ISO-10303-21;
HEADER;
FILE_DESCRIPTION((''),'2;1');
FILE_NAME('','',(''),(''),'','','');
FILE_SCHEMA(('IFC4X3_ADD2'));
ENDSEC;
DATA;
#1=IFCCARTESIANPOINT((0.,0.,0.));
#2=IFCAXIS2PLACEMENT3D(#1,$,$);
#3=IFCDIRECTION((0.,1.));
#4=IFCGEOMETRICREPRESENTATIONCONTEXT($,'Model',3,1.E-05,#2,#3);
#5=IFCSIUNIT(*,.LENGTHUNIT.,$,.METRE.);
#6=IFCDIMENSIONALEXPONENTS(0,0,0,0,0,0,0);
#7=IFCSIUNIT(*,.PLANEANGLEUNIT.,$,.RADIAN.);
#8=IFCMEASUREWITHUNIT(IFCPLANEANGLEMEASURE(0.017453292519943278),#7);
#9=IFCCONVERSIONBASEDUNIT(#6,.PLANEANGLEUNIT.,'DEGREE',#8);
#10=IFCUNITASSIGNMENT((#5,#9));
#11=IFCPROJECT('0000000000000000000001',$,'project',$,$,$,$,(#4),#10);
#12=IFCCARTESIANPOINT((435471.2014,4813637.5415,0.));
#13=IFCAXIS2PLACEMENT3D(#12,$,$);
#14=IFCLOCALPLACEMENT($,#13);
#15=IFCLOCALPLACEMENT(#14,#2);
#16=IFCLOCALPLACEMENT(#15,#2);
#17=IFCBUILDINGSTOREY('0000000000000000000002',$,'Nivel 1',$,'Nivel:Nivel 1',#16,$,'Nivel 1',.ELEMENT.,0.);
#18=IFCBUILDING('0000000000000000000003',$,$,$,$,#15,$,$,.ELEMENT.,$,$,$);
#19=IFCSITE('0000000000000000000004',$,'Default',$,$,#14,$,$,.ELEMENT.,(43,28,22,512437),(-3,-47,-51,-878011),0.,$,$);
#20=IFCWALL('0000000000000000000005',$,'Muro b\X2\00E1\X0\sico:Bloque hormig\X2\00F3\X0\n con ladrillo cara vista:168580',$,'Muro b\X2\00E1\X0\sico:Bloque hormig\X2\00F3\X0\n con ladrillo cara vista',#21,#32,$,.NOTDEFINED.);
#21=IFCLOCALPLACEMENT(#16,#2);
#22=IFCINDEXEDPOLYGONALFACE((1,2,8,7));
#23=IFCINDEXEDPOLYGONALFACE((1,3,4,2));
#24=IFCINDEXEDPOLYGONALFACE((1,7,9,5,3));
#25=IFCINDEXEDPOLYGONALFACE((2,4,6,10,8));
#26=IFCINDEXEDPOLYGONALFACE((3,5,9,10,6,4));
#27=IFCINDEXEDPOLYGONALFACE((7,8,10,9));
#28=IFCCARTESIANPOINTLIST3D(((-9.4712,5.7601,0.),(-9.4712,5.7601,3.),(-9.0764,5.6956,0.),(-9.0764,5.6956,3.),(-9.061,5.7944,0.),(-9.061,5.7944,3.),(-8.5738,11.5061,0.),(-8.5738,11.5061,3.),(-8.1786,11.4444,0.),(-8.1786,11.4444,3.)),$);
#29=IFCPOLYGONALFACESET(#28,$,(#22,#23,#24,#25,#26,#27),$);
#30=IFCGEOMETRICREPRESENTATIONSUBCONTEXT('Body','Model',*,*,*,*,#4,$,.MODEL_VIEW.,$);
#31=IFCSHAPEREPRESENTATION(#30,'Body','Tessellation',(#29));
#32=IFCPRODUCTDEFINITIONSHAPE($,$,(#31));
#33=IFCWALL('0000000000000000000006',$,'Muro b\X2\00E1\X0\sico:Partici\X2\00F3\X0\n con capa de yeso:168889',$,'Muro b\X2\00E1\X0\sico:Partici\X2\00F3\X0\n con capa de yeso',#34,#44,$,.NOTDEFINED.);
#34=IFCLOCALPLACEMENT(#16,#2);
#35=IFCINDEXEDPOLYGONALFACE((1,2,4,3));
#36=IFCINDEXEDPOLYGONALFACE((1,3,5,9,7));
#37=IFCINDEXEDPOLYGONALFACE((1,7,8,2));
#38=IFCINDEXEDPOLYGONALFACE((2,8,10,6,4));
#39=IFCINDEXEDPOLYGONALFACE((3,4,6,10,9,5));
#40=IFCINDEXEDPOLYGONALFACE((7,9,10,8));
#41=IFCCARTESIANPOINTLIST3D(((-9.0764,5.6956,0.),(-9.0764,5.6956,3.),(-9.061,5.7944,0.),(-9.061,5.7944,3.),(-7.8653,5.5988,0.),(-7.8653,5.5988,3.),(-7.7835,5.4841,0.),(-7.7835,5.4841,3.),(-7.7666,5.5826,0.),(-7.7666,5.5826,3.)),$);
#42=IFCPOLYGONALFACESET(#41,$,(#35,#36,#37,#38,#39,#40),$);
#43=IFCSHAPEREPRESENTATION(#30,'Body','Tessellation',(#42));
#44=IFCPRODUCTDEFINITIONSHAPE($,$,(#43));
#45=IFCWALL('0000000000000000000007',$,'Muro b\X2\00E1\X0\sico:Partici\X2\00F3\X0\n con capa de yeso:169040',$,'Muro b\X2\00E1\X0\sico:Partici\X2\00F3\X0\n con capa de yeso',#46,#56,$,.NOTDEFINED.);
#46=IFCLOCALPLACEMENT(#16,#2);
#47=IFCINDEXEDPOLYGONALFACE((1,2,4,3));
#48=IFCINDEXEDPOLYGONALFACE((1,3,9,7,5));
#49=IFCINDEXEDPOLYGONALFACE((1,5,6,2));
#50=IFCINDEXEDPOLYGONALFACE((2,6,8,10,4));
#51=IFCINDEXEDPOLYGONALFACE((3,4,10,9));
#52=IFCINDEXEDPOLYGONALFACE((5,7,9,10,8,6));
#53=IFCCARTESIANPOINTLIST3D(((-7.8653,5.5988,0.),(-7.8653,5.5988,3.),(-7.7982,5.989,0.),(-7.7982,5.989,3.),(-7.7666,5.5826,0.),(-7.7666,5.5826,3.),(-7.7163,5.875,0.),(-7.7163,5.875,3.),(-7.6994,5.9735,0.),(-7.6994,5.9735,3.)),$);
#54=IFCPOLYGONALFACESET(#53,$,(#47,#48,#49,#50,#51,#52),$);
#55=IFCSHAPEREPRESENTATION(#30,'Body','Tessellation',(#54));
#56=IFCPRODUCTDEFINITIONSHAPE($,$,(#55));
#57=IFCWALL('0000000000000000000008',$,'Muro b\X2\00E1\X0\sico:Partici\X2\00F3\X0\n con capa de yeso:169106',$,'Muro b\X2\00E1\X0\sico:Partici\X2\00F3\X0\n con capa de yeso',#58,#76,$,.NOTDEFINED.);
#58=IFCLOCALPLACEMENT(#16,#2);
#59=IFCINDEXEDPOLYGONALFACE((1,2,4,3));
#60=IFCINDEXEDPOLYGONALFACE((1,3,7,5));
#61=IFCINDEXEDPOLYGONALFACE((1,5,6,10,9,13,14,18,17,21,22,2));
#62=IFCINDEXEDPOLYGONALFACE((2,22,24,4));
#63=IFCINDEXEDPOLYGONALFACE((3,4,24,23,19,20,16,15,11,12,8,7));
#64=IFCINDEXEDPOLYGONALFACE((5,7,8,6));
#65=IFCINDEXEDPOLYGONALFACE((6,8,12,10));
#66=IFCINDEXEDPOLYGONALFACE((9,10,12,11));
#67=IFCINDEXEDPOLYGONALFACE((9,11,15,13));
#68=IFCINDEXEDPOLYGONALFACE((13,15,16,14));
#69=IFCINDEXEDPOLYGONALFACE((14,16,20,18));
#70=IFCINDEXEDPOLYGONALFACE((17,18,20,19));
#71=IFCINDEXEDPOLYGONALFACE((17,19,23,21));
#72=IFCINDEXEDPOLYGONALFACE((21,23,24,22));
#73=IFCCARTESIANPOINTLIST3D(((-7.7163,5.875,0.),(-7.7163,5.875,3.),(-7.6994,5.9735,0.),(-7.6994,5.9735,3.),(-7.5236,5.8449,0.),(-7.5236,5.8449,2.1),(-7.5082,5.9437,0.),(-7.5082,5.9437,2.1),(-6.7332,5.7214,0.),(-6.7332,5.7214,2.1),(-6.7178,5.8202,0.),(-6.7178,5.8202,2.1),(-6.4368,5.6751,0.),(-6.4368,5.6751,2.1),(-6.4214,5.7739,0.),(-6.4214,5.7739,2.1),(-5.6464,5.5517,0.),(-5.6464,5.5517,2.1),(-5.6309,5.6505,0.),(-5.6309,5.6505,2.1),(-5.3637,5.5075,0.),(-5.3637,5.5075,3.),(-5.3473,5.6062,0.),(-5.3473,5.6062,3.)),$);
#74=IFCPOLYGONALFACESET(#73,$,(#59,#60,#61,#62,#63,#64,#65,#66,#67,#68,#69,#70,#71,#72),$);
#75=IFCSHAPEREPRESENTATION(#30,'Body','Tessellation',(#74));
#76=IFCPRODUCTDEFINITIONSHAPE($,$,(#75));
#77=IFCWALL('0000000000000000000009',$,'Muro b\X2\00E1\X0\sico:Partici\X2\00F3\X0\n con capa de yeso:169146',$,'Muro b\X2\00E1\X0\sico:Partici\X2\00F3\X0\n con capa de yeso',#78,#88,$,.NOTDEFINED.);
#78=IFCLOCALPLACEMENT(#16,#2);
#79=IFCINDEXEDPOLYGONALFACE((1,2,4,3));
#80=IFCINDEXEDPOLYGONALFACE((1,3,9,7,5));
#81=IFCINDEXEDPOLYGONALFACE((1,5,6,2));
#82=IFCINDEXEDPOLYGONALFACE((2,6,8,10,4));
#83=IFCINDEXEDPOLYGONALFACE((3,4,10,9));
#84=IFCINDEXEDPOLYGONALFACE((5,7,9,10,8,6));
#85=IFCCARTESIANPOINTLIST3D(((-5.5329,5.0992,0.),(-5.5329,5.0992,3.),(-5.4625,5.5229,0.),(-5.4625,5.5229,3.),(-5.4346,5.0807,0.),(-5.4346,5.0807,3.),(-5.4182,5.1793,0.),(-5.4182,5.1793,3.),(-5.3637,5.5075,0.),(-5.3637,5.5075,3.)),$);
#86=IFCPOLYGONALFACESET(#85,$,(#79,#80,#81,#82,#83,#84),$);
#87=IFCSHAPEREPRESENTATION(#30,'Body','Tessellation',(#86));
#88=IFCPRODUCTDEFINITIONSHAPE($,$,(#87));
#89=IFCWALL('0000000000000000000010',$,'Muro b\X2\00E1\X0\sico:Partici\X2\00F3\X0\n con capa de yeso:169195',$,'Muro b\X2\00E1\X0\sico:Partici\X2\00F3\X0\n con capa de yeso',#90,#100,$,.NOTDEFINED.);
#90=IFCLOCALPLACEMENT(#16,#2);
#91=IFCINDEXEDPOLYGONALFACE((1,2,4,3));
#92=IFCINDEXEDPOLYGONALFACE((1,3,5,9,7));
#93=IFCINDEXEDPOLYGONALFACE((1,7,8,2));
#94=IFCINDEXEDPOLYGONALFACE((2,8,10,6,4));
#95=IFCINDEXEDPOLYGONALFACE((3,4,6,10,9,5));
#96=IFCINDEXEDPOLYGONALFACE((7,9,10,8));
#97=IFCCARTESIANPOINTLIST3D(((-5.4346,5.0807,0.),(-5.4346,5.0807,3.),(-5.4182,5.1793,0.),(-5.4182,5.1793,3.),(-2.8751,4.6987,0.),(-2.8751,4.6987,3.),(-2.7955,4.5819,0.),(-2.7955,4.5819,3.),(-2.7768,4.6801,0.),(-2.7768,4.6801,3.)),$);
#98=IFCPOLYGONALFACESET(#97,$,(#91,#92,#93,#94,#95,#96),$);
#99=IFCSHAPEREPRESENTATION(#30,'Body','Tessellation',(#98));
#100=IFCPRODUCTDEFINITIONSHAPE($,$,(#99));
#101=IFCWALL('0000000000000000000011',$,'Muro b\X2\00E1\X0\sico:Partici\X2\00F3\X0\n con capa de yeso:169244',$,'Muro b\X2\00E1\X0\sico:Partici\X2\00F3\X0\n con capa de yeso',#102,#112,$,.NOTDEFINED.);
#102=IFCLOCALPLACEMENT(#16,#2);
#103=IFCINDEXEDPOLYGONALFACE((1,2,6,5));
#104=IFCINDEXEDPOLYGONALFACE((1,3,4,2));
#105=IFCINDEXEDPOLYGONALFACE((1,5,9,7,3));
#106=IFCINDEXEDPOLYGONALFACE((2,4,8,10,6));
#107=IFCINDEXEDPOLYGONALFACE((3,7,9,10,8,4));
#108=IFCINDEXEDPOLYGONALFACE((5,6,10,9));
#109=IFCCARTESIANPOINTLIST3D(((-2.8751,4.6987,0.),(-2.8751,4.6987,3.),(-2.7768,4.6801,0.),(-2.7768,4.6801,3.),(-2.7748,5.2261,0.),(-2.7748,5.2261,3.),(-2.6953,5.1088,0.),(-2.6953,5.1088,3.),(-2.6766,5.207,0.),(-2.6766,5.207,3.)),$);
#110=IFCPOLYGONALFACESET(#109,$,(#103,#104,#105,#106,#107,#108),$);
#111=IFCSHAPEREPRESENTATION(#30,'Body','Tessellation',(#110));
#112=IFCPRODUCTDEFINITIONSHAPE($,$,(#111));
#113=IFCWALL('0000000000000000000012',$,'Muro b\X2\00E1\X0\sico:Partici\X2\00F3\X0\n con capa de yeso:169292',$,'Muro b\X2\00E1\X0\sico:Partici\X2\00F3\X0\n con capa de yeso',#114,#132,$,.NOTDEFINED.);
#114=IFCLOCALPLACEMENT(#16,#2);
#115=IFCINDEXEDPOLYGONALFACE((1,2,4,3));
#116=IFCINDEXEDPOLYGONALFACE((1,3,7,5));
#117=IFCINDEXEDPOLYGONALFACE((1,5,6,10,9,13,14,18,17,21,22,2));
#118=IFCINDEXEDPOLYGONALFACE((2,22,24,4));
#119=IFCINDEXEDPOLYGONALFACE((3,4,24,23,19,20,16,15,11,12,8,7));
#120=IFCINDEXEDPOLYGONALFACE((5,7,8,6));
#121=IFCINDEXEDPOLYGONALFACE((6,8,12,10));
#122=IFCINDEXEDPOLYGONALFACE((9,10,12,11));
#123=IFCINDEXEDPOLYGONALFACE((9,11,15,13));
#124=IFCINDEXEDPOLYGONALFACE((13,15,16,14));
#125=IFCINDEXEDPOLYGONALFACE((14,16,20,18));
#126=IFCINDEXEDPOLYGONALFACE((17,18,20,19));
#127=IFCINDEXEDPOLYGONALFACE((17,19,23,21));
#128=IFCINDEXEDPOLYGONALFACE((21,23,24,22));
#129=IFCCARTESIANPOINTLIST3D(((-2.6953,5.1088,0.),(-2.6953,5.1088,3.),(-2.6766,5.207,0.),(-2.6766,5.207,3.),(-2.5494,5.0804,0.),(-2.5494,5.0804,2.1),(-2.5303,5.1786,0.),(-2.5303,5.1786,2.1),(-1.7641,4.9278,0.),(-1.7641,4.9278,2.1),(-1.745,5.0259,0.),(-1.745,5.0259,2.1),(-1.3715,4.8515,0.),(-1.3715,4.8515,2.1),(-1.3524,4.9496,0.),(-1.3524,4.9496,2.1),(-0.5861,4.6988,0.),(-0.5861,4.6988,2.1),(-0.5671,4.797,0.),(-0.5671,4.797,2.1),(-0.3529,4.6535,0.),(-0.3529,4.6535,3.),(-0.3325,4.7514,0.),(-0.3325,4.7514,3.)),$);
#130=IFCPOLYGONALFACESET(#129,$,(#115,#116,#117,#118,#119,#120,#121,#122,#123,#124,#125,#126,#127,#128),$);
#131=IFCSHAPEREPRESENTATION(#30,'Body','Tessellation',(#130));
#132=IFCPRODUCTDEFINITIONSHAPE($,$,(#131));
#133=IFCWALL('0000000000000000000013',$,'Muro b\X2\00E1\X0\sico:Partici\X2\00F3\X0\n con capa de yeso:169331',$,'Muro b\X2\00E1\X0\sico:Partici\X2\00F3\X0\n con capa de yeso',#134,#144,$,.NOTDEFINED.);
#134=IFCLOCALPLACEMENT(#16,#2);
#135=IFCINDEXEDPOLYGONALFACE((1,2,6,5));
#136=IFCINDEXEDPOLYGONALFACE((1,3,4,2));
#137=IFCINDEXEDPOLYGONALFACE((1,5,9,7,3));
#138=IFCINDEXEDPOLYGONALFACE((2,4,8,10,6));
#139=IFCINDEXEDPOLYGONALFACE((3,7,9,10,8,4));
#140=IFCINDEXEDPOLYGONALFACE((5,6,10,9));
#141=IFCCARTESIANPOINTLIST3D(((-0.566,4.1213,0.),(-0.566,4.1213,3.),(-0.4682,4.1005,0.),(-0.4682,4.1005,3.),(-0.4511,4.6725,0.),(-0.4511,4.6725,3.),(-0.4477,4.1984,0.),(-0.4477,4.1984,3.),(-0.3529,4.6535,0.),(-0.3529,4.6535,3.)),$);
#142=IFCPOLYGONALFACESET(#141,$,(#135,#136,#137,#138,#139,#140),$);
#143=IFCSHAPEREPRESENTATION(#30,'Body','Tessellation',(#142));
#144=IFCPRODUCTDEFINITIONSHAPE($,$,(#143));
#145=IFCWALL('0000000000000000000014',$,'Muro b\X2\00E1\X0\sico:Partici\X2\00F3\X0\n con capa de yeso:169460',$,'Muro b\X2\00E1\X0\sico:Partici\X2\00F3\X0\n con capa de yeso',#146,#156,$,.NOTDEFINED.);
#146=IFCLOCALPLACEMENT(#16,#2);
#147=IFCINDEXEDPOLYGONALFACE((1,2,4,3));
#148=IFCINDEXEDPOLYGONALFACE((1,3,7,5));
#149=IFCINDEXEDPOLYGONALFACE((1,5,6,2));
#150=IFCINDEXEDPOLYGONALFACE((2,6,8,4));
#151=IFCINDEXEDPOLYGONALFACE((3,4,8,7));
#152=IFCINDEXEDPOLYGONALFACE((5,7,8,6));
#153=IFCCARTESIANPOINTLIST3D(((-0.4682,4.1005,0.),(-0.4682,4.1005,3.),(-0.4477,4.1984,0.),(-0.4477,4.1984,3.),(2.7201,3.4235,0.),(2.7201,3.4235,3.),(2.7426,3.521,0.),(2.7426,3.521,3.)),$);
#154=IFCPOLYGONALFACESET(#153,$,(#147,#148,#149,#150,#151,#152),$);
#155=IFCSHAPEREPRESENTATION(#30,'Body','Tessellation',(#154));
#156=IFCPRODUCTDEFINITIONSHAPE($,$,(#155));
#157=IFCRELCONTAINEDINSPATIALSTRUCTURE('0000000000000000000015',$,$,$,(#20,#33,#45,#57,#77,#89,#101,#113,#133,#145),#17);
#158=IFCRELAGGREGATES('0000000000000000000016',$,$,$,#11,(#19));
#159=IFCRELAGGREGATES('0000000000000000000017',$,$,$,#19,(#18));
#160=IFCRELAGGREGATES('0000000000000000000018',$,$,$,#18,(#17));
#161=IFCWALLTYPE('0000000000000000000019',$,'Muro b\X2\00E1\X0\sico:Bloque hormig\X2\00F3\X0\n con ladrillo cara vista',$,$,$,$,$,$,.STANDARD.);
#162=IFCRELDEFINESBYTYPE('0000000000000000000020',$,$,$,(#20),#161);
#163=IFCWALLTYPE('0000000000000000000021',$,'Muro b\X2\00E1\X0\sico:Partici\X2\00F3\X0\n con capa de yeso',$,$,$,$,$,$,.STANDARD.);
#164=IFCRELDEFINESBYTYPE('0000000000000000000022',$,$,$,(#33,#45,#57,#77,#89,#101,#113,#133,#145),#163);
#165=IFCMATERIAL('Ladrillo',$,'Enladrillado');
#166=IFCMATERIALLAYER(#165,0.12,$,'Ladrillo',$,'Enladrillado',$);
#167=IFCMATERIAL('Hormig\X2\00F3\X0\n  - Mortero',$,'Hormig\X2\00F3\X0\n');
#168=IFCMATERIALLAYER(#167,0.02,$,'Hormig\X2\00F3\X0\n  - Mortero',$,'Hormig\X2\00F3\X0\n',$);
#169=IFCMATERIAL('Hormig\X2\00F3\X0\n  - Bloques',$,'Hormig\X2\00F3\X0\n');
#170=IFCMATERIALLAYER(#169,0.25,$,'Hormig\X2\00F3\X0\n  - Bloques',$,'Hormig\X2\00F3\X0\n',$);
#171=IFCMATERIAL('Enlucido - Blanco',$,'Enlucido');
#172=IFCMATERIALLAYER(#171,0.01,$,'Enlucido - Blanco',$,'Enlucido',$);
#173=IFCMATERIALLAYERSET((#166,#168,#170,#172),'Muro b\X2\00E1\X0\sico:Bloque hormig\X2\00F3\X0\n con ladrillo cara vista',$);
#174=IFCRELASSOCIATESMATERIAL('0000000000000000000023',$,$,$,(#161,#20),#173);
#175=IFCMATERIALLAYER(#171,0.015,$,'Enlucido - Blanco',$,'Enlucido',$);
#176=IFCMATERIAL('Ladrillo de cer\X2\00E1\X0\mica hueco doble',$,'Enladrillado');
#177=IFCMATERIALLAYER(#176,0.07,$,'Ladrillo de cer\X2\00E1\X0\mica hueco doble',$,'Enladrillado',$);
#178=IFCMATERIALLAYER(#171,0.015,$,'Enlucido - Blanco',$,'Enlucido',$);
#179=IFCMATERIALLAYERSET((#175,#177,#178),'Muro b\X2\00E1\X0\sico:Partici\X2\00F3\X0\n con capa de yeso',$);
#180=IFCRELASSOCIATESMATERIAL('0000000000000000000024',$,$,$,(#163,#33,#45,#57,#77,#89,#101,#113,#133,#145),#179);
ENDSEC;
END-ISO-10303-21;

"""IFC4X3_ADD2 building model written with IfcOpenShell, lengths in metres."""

from ifc_helpers import new_model, entity, si_unit, converted_unit, direction, frame, frame_2d, origin, place, context, subcontext, project, spatial, polyline, rectangle, outline, extrude, material, layer, layer_set, type_object, element, save


model = new_model("IFC4X3_ADD2")

# Units and contexts
model_context = context("Model", 3, precision=1e-05, world=origin(), true_north=direction((0.0, 1.0)))
body_context = subcontext(model_context, "Body", "Model", "MODEL_VIEW")
ifc_project = project(units=[si_unit("LENGTHUNIT", "METRE"), converted_unit("PLANEANGLEUNIT", "DEGREE", entity("IfcPlaneAngleMeasure", 0.017453292519943278), si_unit("PLANEANGLEUNIT", "RADIAN"), dimensions=[0, 0, 0, 0, 0, 0, 0])], contexts=[model_context])

# Site, building, storey
site_placement = place(None, frame((435471.2014, 4813637.5415, 0.0)))
site = spatial("IfcSite", under=ifc_project, at=site_placement, Name="Default", CompositionType="ELEMENT", RefLatitude=(43, 28, 22, 512437), RefLongitude=(-3, -47, -51, -878011), RefElevation=0.0)
building_placement = place(site_placement, origin())
building = spatial("IfcBuilding", under=site, at=building_placement, CompositionType="ELEMENT")
storey_placement = place(building_placement, origin())
storey = spatial("IfcBuildingStorey", under=building, at=storey_placement, Name="Nivel 1", ObjectType="Nivel:Nivel 1", LongName="Nivel 1", CompositionType="ELEMENT", Elevation=0.0)

# Walls
ifc_material_1 = material(Name="Ladrillo", Category="Enladrillado")
ifc_layer_1 = layer(ifc_material_1, 0.12, Name="Ladrillo", Category="Enladrillado")
ifc_material_2 = material(Name="Hormigón  - Mortero", Category="Hormigón")
ifc_layer_2 = layer(ifc_material_2, 0.02, Name="Hormigón  - Mortero", Category="Hormigón")
ifc_material_3 = material(Name="Hormigón  - Bloques", Category="Hormigón")
ifc_layer_3 = layer(ifc_material_3, 0.25, Name="Hormigón  - Bloques", Category="Hormigón")
ifc_material_4 = material(Name="Enlucido - Blanco", Category="Enlucido")
ifc_layer_4 = layer(ifc_material_4, 0.01, Name="Enlucido - Blanco", Category="Enlucido")
ifc_layer_set_1 = layer_set([ifc_layer_1, ifc_layer_2, ifc_layer_3, ifc_layer_4], Name="Muro básico:Bloque hormigón con ladrillo cara vista")
wall_type_1 = type_object("IfcWallType", Name="Muro básico:Bloque hormigón con ladrillo cara vista", PredefinedType="STANDARD", material=ifc_layer_set_1)
wall_1_placement = place(storey_placement, frame((-8.3762, 11.4752, 0.0), z_axis=(0.0, 0.0, 1.0), x_axis=(-0.154315, -0.988022, 0.0)))
element("IfcWall", 1, at=wall_1_placement, inside=storey, type_object=wall_type_1, material=ifc_layer_set_1, Name="Muro básico:Bloque hormigón con ladrillo cara vista:168580", ObjectType="Muro básico:Bloque hormigón con ladrillo cara vista", PredefinedType="NOTDEFINED", context=body_context, shape_type="SweptSolid", body=[
    extrude(outline(polyline([(5.8156, -0.2), (5.8185, 0.2), (5.7185, 0.2), (0.0, 0.2), (0.0, -0.2), (5.8156, -0.2)])), origin(), (0.0, 0.0, 1.0), 3.0),
])
ifc_layer_5 = layer(ifc_material_4, 0.015, Name="Enlucido - Blanco", Category="Enlucido")
ifc_material_5 = material(Name="Ladrillo de cerámica hueco doble", Category="Enladrillado")
ifc_layer_6 = layer(ifc_material_5, 0.07, Name="Ladrillo de cerámica hueco doble", Category="Enladrillado")
ifc_layer_7 = layer(ifc_material_4, 0.015, Name="Enlucido - Blanco", Category="Enlucido")
ifc_layer_set_2 = layer_set([ifc_layer_5, ifc_layer_6, ifc_layer_7], Name="Muro básico:Partición con capa de yeso")
wall_type_2 = type_object("IfcWallType", Name="Muro básico:Partición con capa de yeso", PredefinedType="STANDARD", material=ifc_layer_set_2)
wall_2_placement = place(storey_placement, frame((-9.0691, 5.745, 0.0), z_axis=(0.0, 0.0, 1.0), x_axis=(0.986886, -0.161421, 0.0)))
element("IfcWall", 2, at=wall_2_placement, inside=storey, type_object=wall_type_2, material=ifc_layer_set_2, Name="Muro básico:Partición con capa de yeso:168889", ObjectType="Muro básico:Partición con capa de yeso", PredefinedType="NOTDEFINED", context=body_context, shape_type="SweptSolid", body=[
    extrude(outline(polyline([(1.3108, -0.05), (1.3116, 0.05), (1.2116, 0.05), (0.0, 0.05), (0.0007, -0.05), (1.3108, -0.05)])), origin(), (0.0, 0.0, 1.0), 3.0),
])
wall_3_placement = place(storey_placement, frame((-7.816, 5.5903, 0.0), z_axis=(0.0, 0.0, 1.0), x_axis=(0.169385, 0.98555, 0.0)))
element("IfcWall", 3, at=wall_3_placement, inside=storey, type_object=wall_type_2, material=ifc_layer_set_2, Name="Muro básico:Partición con capa de yeso:169040", ObjectType="Muro básico:Partición con capa de yeso", PredefinedType="NOTDEFINED", context=body_context, shape_type="SweptSolid", body=[
    extrude(outline(polyline([(0.3974, -0.05), (0.3959, 0.05), (0.0, 0.05), (0.0008, -0.05), (0.2974, -0.05), (0.3974, -0.05)])), origin(), (0.0, 0.0, 1.0), 3.0),
])

# Wall, openings
wall_4_placement = place(storey_placement, frame((-7.7086, 5.9244, 0.0), z_axis=(0.0, 0.0, 1.0), x_axis=(0.988022, -0.154315, 0.0)))
wall_4 = element("IfcWall", 4, at=wall_4_placement, inside=storey, type_object=wall_type_2, material=ifc_layer_set_2, Name="Muro básico:Partición con capa de yeso:169106", ObjectType="Muro básico:Partición con capa de yeso", PredefinedType="NOTDEFINED", context=body_context, shape_type="SweptSolid", body=[
    extrude(outline(polyline([(0.0, -0.05), (2.2812, -0.05), (2.3812, -0.05), (2.3822, 0.05), (0.0015, 0.05), (0.0, -0.05)])), origin(), (0.0, 0.0, 1.0), 3.0),
])
opening_1_placement = place(wall_4_placement, frame((0.1951, -0.05, 0.0)))
element("IfcOpeningElement", 5, at=opening_1_placement, cuts=wall_4, PredefinedType="OPENING", context=body_context, shape_type="SweptSolid", body=[
    extrude(rectangle(XDim=2.1, YDim=0.8, at=frame_2d((1.05, 0.4), x_axis=(1.0, 0.0))), frame((0.0, 0.0, 0.0), z_axis=(0.0, 1.0, 0.0), x_axis=(0.0, 0.0, 1.0)), (0.0, 0.0, 1.0), 0.1),
])
opening_2_placement = place(wall_4_placement, frame((1.2951, -0.05, 0.0)))
element("IfcOpeningElement", 6, at=opening_2_placement, cuts=wall_4, PredefinedType="OPENING", context=body_context, shape_type="SweptSolid", body=[
    extrude(rectangle(XDim=2.1, YDim=0.8, at=frame_2d((1.05, 0.4), x_axis=(1.0, 0.0))), frame((0.0, 0.0, 0.0), z_axis=(0.0, 1.0, 0.0), x_axis=(0.0, 0.0, 1.0)), (0.0, 0.0, 1.0), 0.1),
])

# Walls
wall_5_placement = place(storey_placement, frame((-5.413, 5.5157, 0.0), z_axis=(0.0, 0.0, 1.0), x_axis=(-0.16397, -0.986465, 0.0)))
element("IfcWall", 7, at=wall_5_placement, inside=storey, type_object=wall_type_2, material=ifc_layer_set_2, Name="Muro básico:Partición con capa de yeso:169146", ObjectType="Muro básico:Partición con capa de yeso", PredefinedType="NOTDEFINED", context=body_context, shape_type="SweptSolid", body=[
    extrude(outline(polyline([(0.4305, -0.05), (0.4327, 0.05), (0.3327, 0.05), (0.0, 0.05), (0.001, -0.05), (0.4305, -0.05)])), origin(), (0.0, 0.0, 1.0), 3.0),
])
wall_6_placement = place(storey_placement, frame((-5.4275, 5.1302, 0.0), z_axis=(0.0, 0.0, 1.0), x_axis=(0.982607, -0.185698, 0.0)))
element("IfcWall", 8, at=wall_6_placement, inside=storey, type_object=wall_type_2, material=ifc_layer_set_2, Name="Muro básico:Partición con capa de yeso:169195", ObjectType="Muro básico:Partición con capa de yeso", PredefinedType="NOTDEFINED", context=body_context, shape_type="SweptSolid", body=[
    extrude(outline(polyline([(2.688, -0.05), (2.6881, 0.05), (2.5881, 0.05), (0.0, 0.05), (0.0022, -0.05), (2.688, -0.05)])), origin(), (0.0, 0.0, 1.0), 3.0),
])
wall_7_placement = place(storey_placement, frame((-2.826, 4.6894, 0.0), z_axis=(0.0, 0.0, 1.0), x_axis=(0.18685, 0.982388, 0.0)))
element("IfcWall", 9, at=wall_7_placement, inside=storey, type_object=wall_type_2, material=ifc_layer_set_2, Name="Muro básico:Partición con capa de yeso:169244", ObjectType="Muro básico:Partición con capa de yeso", PredefinedType="NOTDEFINED", context=body_context, shape_type="SweptSolid", body=[
    extrude(outline(polyline([(0.5364, -0.05), (0.5368, 0.05), (0.0, 0.05), (0.0001, -0.05), (0.4364, -0.05), (0.5364, -0.05)])), origin(), (0.0, 0.0, 1.0), 3.0),
])

# Wall, openings
wall_8_placement = place(storey_placement, frame((-2.6862, 5.1579, 0.0), z_axis=(0.0, 0.0, 1.0), x_axis=(0.981627, -0.190809, 0.0)))
wall_8 = element("IfcWall", 10, at=wall_8_placement, inside=storey, type_object=wall_type_2, material=ifc_layer_set_2, Name="Muro básico:Partición con capa de yeso:169292", ObjectType="Muro básico:Partición con capa de yeso", PredefinedType="NOTDEFINED", context=body_context, shape_type="SweptSolid", body=[
    extrude(outline(polyline([(0.0004, -0.05), (2.2867, -0.05), (2.3867, -0.05), (2.388, 0.05), (0.0, 0.05), (0.0004, -0.05)])), origin(), (0.0, 0.0, 1.0), 3.0),
])
opening_3_placement = place(wall_8_placement, frame((1.349, -0.05, 0.0)))
element("IfcOpeningElement", 11, at=opening_3_placement, cuts=wall_8, PredefinedType="OPENING", context=body_context, shape_type="SweptSolid", body=[
    extrude(rectangle(XDim=2.1, YDim=0.8, at=frame_2d((1.05, 0.4), x_axis=(1.0, 0.0))), frame((0.0, 0.0, 0.0), z_axis=(0.0, 1.0, 0.0), x_axis=(0.0, 0.0, 1.0)), (0.0, 0.0, 1.0), 0.1),
])
opening_4_placement = place(wall_8_placement, frame((0.149, -0.05, 0.0)))
element("IfcOpeningElement", 12, at=opening_4_placement, cuts=wall_8, PredefinedType="OPENING", context=body_context, shape_type="SweptSolid", body=[
    extrude(rectangle(XDim=2.1, YDim=0.8, at=frame_2d((1.05, 0.4), x_axis=(1.0, 0.0))), frame((0.0, 0.0, 0.0), z_axis=(0.0, 1.0, 0.0), x_axis=(0.0, 0.0, 1.0)), (0.0, 0.0, 1.0), 0.1),
])

# Walls
wall_9_placement = place(storey_placement, frame((-0.4018, 4.6637, 0.0), z_axis=(0.0, 0.0, 1.0), x_axis=(-0.204054, -0.97896, 0.0)))
element("IfcWall", 13, at=wall_9_placement, inside=storey, type_object=wall_type_2, material=ifc_layer_set_2, Name="Muro básico:Partición con capa de yeso:169331", ObjectType="Muro básico:Partición con capa de yeso", PredefinedType="NOTDEFINED", context=body_context, shape_type="SweptSolid", body=[
    extrude(outline(polyline([(0.5645, -0.05), (0.5648, 0.05), (0.4648, 0.05), (0.0, 0.05), (0.0014, -0.05), (0.5645, -0.05)])), origin(), (0.0, 0.0, 1.0), 3.0),
])
wall_10_placement = place(storey_placement, frame((-0.4581, 4.1495, 0.0), z_axis=(0.0, 0.0, 1.0), x_axis=(0.978192, -0.207703, 0.0)))
element("IfcWall", 14, at=wall_10_placement, inside=storey, type_object=wall_type_2, material=ifc_layer_set_2, Name="Muro básico:Partición con capa de yeso:169460", ObjectType="Muro básico:Partición con capa de yeso", PredefinedType="NOTDEFINED", context=body_context, shape_type="SweptSolid", body=[
    extrude(outline(polyline([(3.2597, -0.05), (3.2615, 0.05), (0.0, 0.05), (0.0004, -0.05), (3.2597, -0.05)])), origin(), (0.0, 0.0, 1.0), 3.0),
])

save(model, "model.ifc")
